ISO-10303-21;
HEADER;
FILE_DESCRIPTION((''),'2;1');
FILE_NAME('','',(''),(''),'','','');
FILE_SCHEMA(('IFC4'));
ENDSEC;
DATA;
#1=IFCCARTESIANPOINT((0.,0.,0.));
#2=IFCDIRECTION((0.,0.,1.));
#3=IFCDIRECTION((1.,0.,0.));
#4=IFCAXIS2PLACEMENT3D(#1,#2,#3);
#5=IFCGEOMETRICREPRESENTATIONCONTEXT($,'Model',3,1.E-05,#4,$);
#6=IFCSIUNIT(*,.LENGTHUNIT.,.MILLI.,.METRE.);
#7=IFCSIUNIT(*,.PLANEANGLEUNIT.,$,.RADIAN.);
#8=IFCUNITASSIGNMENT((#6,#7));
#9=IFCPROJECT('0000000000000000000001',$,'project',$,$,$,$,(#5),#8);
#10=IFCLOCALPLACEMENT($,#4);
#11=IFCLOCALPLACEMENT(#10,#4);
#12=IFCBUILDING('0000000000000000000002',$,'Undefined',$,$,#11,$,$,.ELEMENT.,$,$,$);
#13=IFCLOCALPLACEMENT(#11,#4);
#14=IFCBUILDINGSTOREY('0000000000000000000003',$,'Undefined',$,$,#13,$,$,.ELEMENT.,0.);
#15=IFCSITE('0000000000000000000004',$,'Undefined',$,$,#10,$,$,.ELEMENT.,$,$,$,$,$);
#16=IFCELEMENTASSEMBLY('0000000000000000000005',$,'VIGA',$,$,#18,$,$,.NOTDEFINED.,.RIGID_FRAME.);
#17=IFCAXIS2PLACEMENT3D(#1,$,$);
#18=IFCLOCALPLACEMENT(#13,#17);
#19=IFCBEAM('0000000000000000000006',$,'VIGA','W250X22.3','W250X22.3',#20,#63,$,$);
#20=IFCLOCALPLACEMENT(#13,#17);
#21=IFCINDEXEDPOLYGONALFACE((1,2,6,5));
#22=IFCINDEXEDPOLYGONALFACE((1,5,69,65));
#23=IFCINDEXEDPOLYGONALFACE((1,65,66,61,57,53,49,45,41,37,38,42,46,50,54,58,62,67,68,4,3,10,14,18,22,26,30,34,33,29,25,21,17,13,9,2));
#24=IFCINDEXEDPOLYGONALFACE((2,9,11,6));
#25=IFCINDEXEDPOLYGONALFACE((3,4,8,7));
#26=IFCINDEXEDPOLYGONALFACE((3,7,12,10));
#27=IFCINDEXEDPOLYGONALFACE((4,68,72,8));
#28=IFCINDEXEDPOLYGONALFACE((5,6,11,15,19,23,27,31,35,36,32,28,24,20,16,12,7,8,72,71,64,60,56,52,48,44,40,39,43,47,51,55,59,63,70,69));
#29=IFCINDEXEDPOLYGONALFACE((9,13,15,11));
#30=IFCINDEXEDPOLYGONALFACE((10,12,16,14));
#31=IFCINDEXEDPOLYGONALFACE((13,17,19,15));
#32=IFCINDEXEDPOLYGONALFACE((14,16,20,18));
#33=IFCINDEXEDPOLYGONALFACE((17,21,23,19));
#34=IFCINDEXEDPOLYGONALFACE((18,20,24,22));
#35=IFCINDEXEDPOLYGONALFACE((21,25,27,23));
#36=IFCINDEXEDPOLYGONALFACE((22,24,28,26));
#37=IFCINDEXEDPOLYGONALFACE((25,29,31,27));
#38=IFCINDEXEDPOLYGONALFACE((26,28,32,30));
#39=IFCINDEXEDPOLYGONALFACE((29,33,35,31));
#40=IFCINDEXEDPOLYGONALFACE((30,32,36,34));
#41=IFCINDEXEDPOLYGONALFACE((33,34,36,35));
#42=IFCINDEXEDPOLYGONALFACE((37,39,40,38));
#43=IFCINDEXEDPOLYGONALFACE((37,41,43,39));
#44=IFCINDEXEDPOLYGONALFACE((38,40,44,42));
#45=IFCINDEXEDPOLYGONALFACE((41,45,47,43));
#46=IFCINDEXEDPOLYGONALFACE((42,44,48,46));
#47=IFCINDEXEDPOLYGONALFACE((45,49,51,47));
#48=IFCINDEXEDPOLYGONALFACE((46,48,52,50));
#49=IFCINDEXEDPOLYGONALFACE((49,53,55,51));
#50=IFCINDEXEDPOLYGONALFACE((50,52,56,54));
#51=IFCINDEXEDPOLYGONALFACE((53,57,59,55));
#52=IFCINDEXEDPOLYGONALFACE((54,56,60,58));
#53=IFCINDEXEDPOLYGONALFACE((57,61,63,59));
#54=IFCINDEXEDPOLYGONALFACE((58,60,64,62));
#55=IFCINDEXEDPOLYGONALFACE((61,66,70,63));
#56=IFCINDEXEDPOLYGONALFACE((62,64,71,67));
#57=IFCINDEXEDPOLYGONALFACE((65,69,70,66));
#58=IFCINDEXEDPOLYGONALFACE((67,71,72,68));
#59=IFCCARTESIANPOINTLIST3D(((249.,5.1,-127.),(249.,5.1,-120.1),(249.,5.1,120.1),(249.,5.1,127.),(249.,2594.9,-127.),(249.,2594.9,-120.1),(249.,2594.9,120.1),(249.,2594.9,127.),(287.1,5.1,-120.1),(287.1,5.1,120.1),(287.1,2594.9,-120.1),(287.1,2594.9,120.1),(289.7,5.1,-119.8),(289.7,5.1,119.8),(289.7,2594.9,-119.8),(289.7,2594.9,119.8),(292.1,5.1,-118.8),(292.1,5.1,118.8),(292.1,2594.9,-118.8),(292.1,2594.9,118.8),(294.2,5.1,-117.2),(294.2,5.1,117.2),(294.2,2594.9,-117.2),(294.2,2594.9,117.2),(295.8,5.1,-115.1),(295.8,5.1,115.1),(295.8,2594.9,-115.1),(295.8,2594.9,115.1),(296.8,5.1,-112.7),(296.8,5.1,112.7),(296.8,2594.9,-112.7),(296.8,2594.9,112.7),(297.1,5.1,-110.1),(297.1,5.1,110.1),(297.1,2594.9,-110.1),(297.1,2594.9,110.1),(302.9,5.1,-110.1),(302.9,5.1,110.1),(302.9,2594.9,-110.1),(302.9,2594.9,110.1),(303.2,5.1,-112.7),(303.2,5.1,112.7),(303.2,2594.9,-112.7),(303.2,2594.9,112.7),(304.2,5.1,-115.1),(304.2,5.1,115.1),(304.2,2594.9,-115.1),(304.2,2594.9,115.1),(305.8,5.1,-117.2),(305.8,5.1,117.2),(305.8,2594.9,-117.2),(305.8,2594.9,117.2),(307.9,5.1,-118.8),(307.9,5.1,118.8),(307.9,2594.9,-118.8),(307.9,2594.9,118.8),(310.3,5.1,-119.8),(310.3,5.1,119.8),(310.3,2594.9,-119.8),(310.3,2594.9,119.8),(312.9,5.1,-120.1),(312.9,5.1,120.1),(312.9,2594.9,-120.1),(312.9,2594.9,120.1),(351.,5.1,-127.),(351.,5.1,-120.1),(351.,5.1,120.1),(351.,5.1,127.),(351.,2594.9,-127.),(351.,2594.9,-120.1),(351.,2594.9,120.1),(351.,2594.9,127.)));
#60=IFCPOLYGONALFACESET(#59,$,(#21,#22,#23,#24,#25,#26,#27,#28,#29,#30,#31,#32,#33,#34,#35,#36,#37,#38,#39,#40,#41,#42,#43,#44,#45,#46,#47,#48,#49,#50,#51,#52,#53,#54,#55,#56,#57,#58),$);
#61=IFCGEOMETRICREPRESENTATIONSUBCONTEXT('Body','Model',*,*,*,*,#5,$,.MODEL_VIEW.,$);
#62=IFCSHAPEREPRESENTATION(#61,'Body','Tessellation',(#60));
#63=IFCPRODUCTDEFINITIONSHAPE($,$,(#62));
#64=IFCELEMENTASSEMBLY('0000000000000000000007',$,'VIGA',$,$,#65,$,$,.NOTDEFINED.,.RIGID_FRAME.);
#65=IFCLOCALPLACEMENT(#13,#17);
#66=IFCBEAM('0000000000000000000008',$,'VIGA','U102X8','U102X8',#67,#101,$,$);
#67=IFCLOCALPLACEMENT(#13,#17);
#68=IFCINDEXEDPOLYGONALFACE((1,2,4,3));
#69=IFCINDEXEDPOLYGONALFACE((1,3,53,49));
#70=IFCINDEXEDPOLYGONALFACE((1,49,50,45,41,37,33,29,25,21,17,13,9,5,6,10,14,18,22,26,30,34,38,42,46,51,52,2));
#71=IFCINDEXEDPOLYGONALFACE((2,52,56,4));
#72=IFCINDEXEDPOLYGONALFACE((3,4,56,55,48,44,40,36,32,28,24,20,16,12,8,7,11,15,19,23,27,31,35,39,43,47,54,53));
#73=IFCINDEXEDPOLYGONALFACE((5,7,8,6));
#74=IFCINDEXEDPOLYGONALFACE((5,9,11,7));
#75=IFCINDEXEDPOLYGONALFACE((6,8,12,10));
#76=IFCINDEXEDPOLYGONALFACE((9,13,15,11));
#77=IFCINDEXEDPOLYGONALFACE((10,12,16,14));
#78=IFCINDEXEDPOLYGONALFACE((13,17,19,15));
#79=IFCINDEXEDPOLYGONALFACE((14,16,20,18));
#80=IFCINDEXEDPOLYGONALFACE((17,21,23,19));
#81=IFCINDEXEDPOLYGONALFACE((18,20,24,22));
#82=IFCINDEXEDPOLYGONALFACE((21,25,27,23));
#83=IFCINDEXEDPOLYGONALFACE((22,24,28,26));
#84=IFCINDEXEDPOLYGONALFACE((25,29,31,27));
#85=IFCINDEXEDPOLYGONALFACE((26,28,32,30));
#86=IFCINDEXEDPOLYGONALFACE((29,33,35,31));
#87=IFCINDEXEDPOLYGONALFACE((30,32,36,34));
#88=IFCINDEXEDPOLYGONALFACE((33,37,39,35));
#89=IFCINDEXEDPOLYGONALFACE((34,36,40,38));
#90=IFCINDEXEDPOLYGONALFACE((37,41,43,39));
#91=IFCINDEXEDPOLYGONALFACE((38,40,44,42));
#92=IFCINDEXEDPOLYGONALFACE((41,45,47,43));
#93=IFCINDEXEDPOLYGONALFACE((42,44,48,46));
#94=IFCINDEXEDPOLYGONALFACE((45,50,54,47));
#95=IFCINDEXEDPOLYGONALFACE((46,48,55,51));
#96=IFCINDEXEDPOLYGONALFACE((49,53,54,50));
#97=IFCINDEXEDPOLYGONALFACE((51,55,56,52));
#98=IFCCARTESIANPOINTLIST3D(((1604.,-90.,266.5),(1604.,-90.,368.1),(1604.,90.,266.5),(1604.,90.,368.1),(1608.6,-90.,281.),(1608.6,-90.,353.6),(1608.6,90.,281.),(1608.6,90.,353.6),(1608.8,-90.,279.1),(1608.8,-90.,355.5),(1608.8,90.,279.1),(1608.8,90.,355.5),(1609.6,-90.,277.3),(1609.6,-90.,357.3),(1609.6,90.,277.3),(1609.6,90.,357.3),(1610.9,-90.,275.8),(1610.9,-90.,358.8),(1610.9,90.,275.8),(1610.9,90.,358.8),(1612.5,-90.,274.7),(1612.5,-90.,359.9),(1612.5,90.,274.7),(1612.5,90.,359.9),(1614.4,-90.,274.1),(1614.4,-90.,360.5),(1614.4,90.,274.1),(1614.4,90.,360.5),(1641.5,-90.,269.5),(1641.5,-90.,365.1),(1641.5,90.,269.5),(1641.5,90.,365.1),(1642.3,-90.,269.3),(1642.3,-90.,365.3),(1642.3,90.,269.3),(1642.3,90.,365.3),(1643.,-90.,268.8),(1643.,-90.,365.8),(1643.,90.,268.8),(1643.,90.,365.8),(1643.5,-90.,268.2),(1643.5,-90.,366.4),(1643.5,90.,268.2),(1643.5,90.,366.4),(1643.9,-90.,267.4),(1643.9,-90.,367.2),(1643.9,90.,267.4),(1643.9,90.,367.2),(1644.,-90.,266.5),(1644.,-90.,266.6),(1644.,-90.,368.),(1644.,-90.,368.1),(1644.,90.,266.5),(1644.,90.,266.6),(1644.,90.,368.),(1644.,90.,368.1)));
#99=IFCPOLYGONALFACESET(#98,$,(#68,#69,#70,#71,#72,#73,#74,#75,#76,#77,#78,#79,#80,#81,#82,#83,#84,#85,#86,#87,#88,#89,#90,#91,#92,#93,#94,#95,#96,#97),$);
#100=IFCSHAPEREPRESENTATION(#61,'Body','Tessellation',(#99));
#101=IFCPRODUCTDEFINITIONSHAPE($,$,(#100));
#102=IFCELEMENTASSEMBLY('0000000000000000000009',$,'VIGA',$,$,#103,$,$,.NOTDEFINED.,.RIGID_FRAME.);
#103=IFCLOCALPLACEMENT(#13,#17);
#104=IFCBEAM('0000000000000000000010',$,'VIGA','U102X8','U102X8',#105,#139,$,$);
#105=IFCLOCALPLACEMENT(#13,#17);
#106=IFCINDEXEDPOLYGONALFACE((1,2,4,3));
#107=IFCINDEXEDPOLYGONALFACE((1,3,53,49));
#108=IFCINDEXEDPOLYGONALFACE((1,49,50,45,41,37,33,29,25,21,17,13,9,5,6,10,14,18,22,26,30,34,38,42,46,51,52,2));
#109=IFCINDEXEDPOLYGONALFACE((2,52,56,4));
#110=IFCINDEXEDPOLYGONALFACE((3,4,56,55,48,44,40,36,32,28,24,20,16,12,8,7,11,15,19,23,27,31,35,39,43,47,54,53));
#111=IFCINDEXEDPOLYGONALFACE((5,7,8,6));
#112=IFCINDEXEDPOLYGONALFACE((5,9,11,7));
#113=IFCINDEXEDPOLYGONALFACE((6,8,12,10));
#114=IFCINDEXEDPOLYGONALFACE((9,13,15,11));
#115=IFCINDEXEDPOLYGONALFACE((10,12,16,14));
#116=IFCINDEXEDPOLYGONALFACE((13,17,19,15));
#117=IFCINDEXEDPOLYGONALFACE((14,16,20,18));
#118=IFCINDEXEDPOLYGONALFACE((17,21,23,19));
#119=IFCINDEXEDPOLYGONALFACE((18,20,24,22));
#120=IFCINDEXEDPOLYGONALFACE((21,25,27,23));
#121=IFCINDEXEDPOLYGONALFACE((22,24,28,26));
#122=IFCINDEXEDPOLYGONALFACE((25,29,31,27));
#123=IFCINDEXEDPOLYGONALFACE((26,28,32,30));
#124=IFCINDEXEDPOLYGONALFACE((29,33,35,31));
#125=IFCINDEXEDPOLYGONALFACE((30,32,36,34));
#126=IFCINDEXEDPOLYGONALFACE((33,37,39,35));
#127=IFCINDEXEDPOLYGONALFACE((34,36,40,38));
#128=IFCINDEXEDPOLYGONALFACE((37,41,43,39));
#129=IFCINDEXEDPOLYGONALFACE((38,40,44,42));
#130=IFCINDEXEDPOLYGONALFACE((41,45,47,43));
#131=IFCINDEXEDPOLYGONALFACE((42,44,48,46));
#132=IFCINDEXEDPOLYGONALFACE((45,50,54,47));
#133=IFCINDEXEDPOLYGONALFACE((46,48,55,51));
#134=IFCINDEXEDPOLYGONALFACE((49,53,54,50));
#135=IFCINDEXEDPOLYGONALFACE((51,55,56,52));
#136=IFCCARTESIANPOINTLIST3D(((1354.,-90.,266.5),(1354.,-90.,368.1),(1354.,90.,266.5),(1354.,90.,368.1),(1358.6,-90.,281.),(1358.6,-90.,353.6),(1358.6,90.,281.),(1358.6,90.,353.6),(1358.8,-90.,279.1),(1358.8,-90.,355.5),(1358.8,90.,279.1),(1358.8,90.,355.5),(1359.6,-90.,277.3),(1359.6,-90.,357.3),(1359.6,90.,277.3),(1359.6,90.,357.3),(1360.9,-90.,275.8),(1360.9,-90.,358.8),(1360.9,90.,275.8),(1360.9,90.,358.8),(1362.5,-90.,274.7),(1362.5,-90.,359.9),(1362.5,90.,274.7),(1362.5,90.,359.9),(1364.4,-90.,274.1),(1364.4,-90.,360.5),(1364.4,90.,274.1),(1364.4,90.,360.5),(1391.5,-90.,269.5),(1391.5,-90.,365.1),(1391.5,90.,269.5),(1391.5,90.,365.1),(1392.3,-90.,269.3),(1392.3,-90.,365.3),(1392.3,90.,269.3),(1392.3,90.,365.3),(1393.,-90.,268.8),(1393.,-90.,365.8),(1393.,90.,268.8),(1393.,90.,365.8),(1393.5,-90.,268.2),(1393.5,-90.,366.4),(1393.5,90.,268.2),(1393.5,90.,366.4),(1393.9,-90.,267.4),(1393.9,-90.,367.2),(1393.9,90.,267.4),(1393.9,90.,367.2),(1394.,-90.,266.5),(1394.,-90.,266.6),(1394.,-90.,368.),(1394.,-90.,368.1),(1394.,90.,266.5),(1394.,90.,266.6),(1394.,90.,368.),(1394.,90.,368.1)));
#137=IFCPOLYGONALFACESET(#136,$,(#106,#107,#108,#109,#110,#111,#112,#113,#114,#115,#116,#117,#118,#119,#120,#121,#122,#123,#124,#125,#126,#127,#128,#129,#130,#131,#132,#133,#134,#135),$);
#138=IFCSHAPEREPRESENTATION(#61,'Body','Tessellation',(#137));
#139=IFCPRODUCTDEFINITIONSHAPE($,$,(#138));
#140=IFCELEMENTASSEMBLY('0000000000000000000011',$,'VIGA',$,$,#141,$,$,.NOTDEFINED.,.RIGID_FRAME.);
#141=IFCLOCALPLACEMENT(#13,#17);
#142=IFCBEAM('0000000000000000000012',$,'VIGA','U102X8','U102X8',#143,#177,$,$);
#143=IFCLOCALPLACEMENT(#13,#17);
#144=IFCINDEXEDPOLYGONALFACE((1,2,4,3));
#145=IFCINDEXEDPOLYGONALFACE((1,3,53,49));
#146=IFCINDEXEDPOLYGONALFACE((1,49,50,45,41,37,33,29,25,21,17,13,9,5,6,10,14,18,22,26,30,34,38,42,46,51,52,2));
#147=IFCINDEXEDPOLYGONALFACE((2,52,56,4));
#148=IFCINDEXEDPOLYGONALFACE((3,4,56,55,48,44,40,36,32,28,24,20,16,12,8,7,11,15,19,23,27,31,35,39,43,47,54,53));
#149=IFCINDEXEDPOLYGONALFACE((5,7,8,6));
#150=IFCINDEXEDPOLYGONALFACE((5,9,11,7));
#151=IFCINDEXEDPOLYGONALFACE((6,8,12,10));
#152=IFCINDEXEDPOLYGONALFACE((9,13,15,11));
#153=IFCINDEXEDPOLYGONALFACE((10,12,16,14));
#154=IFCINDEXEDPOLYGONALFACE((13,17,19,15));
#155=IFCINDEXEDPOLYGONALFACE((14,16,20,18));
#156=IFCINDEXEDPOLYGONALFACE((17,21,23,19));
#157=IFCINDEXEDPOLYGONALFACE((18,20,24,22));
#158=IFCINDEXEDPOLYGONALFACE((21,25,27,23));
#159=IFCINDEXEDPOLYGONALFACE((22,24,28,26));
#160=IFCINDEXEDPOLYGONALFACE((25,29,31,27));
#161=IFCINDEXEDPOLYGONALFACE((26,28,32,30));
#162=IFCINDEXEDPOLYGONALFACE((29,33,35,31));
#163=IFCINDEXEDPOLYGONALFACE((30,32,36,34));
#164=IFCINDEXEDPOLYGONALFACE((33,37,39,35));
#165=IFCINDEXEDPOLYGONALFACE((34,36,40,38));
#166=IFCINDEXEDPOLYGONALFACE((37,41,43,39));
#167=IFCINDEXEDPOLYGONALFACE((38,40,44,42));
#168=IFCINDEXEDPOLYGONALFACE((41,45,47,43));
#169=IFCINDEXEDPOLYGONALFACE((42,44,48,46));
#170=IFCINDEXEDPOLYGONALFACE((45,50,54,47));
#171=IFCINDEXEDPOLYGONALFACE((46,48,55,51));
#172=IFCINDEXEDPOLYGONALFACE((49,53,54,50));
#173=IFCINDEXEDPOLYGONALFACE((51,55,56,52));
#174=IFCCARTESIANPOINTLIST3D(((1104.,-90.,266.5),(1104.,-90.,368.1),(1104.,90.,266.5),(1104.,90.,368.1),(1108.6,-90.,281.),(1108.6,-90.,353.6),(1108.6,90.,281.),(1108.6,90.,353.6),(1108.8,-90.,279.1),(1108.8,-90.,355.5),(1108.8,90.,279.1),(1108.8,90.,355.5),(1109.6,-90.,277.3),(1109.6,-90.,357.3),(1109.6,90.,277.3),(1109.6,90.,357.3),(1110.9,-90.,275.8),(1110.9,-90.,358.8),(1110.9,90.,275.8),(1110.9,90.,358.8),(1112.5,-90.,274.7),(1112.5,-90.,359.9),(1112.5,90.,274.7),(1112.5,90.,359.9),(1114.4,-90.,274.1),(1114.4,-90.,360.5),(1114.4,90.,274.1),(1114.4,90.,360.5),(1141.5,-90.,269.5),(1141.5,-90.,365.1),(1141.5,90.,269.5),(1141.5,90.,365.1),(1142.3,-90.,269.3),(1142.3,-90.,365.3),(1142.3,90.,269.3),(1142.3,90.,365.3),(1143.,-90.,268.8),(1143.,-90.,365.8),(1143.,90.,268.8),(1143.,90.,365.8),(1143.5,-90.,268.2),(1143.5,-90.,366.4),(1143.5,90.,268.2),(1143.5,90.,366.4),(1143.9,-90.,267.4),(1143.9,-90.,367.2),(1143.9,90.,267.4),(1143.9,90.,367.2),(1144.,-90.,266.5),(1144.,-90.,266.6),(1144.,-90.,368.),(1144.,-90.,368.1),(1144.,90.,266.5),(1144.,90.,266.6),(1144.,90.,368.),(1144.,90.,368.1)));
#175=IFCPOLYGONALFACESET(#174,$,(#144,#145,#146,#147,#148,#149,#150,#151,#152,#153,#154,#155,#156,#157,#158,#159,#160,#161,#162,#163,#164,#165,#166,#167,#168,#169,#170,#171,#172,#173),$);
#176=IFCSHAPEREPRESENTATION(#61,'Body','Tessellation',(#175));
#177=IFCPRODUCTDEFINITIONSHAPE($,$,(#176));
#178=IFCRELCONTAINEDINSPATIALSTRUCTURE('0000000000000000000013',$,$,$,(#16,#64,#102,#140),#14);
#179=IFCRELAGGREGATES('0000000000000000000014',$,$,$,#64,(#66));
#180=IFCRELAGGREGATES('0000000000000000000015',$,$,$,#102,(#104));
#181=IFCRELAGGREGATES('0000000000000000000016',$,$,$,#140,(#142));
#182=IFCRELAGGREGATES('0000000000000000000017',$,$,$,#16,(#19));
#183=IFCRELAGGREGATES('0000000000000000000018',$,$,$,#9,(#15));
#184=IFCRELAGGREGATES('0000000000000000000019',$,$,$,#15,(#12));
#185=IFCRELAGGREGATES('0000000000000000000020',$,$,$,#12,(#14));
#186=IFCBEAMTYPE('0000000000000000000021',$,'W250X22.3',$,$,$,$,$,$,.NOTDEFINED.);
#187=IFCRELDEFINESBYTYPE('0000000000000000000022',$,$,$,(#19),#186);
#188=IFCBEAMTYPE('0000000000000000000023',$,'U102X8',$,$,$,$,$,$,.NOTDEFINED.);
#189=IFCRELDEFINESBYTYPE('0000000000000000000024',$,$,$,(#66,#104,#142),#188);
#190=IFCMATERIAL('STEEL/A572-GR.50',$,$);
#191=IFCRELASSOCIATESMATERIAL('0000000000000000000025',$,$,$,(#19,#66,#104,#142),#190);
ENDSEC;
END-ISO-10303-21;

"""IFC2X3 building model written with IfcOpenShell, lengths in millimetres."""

from ifc_helpers import new_model, si_unit, frame, origin_with_axes, origin_2d_with_axis, place, context, subcontext, project, spatial, i_section, u_section, extrude, material, type_object, element, aggregate, save


model = new_model("IFC2X3")

# Units and contexts
model_context = context("Model", 3, precision=1e-05, world=origin_with_axes())
body_context = subcontext(model_context, "Body", "Model", "MODEL_VIEW")
ifc_project = project(units=[si_unit("LENGTHUNIT", "METRE", prefix="MILLI"), si_unit("PLANEANGLEUNIT", "RADIAN")], contexts=[model_context])

# Site, building, storey
site_placement = place(None, origin_with_axes())
site = spatial("IfcSite", under=ifc_project, at=site_placement, Name="Undefined", CompositionType="ELEMENT")
building_placement = place(site_placement, origin_with_axes())
building = spatial("IfcBuilding", under=site, at=building_placement, Name="Undefined", CompositionType="ELEMENT")
storey_placement = place(building_placement, origin_with_axes())
storey = spatial("IfcBuildingStorey", under=building, at=storey_placement, Name="Undefined", CompositionType="ELEMENT", Elevation=0.0)

# Element assemblies, beams
assembly_1_placement = place(storey_placement, origin_with_axes())
assembly_1 = element("IfcElementAssembly", 1, at=assembly_1_placement, inside=storey, Name="VIGA", AssemblyPlace="NOTDEFINED", PredefinedType="RIGID_FRAME")
ifc_material_1 = material(Name="STEEL/A572-GR.50")
beam_type_1 = type_object("IfcBeamType", Name="W250X22.3", PredefinedType="NOTDEFINED")
beam_1_placement = place(assembly_1_placement, frame((300.0, 5.1, 0.0), z_axis=(0.0, 0.0, 1.0), x_axis=(0.0, 1.0, 0.0)))
beam_1 = element("IfcBeam", 2, at=beam_1_placement, type_object=beam_type_1, material=ifc_material_1, Name="VIGA", Description="W250X22.3", ObjectType="W250X22.3", context=body_context, shape_type="SweptSolid", body=[
    extrude(i_section(OverallWidth=102.0, OverallDepth=254.0, WebThickness=5.8, FlangeThickness=6.9, FilletRadius=10.0, at=origin_2d_with_axis()), frame((2589.8, 0.0, 0.0), z_axis=(-1.0, 0.0, 0.0), x_axis=(0.0, -1.0, 0.0)), (0.0, 0.0, 1.0), 2589.8),
])
assembly_2_placement = place(storey_placement, origin_with_axes())
assembly_2 = element("IfcElementAssembly", 3, at=assembly_2_placement, inside=storey, Name="VIGA", AssemblyPlace="NOTDEFINED", PredefinedType="RIGID_FRAME")
beam_type_2 = type_object("IfcBeamType", Name="U102X8", PredefinedType="NOTDEFINED")
beam_2_placement = place(assembly_2_placement, frame((1624.0, -90.0, 317.3), z_axis=(0.0, 0.0, 1.0), x_axis=(0.0, 1.0, 0.0)))
beam_2 = element("IfcBeam", 4, at=beam_2_placement, type_object=beam_type_2, material=ifc_material_1, Name="VIGA", Description="U102X8", ObjectType="U102X8", context=body_context, shape_type="SweptSolid", body=[
    extrude(u_section(Depth=101.6, FlangeWidth=40.0, WebThickness=4.6, FlangeThickness=6.0, FilletRadius=7.0, EdgeRadius=3.0, FlangeSlope=0.16839, at=origin_2d_with_axis()), frame((180.0, 0.0, 0.0), z_axis=(-1.0, 0.0, 0.0), x_axis=(0.0, -1.0, 0.0)), (0.0, 0.0, 1.0), 180.0),
])
aggregate(assembly_2, [beam_2])
assembly_3_placement = place(storey_placement, origin_with_axes())
assembly_3 = element("IfcElementAssembly", 5, at=assembly_3_placement, inside=storey, Name="VIGA", AssemblyPlace="NOTDEFINED", PredefinedType="RIGID_FRAME")
beam_3_placement = place(assembly_3_placement, frame((1374.0, -90.0, 317.3), z_axis=(0.0, 0.0, 1.0), x_axis=(0.0, 1.0, 0.0)))
beam_3 = element("IfcBeam", 6, at=beam_3_placement, type_object=beam_type_2, material=ifc_material_1, Name="VIGA", Description="U102X8", ObjectType="U102X8", context=body_context, shape_type="SweptSolid", body=[
    extrude(u_section(Depth=101.6, FlangeWidth=40.0, WebThickness=4.6, FlangeThickness=6.0, FilletRadius=7.0, EdgeRadius=3.0, FlangeSlope=0.16839, at=origin_2d_with_axis()), frame((180.0, 0.0, 0.0), z_axis=(-1.0, 0.0, 0.0), x_axis=(0.0, -1.0, 0.0)), (0.0, 0.0, 1.0), 180.0),
])
aggregate(assembly_3, [beam_3])
assembly_4_placement = place(storey_placement, origin_with_axes())
assembly_4 = element("IfcElementAssembly", 7, at=assembly_4_placement, inside=storey, Name="VIGA", AssemblyPlace="NOTDEFINED", PredefinedType="RIGID_FRAME")
beam_4_placement = place(assembly_4_placement, frame((1124.0, -90.0, 317.3), z_axis=(0.0, 0.0, 1.0), x_axis=(0.0, 1.0, 0.0)))
beam_4 = element("IfcBeam", 8, at=beam_4_placement, type_object=beam_type_2, material=ifc_material_1, Name="VIGA", Description="U102X8", ObjectType="U102X8", context=body_context, shape_type="SweptSolid", body=[
    extrude(u_section(Depth=101.6, FlangeWidth=40.0, WebThickness=4.6, FlangeThickness=6.0, FilletRadius=7.0, EdgeRadius=3.0, FlangeSlope=0.16839, at=origin_2d_with_axis()), frame((180.0, 0.0, 0.0), z_axis=(-1.0, 0.0, 0.0), x_axis=(0.0, -1.0, 0.0)), (0.0, 0.0, 1.0), 180.0),
])
aggregate(assembly_4, [beam_4])

aggregate(assembly_1, [beam_1])

save(model, "model.ifc")
